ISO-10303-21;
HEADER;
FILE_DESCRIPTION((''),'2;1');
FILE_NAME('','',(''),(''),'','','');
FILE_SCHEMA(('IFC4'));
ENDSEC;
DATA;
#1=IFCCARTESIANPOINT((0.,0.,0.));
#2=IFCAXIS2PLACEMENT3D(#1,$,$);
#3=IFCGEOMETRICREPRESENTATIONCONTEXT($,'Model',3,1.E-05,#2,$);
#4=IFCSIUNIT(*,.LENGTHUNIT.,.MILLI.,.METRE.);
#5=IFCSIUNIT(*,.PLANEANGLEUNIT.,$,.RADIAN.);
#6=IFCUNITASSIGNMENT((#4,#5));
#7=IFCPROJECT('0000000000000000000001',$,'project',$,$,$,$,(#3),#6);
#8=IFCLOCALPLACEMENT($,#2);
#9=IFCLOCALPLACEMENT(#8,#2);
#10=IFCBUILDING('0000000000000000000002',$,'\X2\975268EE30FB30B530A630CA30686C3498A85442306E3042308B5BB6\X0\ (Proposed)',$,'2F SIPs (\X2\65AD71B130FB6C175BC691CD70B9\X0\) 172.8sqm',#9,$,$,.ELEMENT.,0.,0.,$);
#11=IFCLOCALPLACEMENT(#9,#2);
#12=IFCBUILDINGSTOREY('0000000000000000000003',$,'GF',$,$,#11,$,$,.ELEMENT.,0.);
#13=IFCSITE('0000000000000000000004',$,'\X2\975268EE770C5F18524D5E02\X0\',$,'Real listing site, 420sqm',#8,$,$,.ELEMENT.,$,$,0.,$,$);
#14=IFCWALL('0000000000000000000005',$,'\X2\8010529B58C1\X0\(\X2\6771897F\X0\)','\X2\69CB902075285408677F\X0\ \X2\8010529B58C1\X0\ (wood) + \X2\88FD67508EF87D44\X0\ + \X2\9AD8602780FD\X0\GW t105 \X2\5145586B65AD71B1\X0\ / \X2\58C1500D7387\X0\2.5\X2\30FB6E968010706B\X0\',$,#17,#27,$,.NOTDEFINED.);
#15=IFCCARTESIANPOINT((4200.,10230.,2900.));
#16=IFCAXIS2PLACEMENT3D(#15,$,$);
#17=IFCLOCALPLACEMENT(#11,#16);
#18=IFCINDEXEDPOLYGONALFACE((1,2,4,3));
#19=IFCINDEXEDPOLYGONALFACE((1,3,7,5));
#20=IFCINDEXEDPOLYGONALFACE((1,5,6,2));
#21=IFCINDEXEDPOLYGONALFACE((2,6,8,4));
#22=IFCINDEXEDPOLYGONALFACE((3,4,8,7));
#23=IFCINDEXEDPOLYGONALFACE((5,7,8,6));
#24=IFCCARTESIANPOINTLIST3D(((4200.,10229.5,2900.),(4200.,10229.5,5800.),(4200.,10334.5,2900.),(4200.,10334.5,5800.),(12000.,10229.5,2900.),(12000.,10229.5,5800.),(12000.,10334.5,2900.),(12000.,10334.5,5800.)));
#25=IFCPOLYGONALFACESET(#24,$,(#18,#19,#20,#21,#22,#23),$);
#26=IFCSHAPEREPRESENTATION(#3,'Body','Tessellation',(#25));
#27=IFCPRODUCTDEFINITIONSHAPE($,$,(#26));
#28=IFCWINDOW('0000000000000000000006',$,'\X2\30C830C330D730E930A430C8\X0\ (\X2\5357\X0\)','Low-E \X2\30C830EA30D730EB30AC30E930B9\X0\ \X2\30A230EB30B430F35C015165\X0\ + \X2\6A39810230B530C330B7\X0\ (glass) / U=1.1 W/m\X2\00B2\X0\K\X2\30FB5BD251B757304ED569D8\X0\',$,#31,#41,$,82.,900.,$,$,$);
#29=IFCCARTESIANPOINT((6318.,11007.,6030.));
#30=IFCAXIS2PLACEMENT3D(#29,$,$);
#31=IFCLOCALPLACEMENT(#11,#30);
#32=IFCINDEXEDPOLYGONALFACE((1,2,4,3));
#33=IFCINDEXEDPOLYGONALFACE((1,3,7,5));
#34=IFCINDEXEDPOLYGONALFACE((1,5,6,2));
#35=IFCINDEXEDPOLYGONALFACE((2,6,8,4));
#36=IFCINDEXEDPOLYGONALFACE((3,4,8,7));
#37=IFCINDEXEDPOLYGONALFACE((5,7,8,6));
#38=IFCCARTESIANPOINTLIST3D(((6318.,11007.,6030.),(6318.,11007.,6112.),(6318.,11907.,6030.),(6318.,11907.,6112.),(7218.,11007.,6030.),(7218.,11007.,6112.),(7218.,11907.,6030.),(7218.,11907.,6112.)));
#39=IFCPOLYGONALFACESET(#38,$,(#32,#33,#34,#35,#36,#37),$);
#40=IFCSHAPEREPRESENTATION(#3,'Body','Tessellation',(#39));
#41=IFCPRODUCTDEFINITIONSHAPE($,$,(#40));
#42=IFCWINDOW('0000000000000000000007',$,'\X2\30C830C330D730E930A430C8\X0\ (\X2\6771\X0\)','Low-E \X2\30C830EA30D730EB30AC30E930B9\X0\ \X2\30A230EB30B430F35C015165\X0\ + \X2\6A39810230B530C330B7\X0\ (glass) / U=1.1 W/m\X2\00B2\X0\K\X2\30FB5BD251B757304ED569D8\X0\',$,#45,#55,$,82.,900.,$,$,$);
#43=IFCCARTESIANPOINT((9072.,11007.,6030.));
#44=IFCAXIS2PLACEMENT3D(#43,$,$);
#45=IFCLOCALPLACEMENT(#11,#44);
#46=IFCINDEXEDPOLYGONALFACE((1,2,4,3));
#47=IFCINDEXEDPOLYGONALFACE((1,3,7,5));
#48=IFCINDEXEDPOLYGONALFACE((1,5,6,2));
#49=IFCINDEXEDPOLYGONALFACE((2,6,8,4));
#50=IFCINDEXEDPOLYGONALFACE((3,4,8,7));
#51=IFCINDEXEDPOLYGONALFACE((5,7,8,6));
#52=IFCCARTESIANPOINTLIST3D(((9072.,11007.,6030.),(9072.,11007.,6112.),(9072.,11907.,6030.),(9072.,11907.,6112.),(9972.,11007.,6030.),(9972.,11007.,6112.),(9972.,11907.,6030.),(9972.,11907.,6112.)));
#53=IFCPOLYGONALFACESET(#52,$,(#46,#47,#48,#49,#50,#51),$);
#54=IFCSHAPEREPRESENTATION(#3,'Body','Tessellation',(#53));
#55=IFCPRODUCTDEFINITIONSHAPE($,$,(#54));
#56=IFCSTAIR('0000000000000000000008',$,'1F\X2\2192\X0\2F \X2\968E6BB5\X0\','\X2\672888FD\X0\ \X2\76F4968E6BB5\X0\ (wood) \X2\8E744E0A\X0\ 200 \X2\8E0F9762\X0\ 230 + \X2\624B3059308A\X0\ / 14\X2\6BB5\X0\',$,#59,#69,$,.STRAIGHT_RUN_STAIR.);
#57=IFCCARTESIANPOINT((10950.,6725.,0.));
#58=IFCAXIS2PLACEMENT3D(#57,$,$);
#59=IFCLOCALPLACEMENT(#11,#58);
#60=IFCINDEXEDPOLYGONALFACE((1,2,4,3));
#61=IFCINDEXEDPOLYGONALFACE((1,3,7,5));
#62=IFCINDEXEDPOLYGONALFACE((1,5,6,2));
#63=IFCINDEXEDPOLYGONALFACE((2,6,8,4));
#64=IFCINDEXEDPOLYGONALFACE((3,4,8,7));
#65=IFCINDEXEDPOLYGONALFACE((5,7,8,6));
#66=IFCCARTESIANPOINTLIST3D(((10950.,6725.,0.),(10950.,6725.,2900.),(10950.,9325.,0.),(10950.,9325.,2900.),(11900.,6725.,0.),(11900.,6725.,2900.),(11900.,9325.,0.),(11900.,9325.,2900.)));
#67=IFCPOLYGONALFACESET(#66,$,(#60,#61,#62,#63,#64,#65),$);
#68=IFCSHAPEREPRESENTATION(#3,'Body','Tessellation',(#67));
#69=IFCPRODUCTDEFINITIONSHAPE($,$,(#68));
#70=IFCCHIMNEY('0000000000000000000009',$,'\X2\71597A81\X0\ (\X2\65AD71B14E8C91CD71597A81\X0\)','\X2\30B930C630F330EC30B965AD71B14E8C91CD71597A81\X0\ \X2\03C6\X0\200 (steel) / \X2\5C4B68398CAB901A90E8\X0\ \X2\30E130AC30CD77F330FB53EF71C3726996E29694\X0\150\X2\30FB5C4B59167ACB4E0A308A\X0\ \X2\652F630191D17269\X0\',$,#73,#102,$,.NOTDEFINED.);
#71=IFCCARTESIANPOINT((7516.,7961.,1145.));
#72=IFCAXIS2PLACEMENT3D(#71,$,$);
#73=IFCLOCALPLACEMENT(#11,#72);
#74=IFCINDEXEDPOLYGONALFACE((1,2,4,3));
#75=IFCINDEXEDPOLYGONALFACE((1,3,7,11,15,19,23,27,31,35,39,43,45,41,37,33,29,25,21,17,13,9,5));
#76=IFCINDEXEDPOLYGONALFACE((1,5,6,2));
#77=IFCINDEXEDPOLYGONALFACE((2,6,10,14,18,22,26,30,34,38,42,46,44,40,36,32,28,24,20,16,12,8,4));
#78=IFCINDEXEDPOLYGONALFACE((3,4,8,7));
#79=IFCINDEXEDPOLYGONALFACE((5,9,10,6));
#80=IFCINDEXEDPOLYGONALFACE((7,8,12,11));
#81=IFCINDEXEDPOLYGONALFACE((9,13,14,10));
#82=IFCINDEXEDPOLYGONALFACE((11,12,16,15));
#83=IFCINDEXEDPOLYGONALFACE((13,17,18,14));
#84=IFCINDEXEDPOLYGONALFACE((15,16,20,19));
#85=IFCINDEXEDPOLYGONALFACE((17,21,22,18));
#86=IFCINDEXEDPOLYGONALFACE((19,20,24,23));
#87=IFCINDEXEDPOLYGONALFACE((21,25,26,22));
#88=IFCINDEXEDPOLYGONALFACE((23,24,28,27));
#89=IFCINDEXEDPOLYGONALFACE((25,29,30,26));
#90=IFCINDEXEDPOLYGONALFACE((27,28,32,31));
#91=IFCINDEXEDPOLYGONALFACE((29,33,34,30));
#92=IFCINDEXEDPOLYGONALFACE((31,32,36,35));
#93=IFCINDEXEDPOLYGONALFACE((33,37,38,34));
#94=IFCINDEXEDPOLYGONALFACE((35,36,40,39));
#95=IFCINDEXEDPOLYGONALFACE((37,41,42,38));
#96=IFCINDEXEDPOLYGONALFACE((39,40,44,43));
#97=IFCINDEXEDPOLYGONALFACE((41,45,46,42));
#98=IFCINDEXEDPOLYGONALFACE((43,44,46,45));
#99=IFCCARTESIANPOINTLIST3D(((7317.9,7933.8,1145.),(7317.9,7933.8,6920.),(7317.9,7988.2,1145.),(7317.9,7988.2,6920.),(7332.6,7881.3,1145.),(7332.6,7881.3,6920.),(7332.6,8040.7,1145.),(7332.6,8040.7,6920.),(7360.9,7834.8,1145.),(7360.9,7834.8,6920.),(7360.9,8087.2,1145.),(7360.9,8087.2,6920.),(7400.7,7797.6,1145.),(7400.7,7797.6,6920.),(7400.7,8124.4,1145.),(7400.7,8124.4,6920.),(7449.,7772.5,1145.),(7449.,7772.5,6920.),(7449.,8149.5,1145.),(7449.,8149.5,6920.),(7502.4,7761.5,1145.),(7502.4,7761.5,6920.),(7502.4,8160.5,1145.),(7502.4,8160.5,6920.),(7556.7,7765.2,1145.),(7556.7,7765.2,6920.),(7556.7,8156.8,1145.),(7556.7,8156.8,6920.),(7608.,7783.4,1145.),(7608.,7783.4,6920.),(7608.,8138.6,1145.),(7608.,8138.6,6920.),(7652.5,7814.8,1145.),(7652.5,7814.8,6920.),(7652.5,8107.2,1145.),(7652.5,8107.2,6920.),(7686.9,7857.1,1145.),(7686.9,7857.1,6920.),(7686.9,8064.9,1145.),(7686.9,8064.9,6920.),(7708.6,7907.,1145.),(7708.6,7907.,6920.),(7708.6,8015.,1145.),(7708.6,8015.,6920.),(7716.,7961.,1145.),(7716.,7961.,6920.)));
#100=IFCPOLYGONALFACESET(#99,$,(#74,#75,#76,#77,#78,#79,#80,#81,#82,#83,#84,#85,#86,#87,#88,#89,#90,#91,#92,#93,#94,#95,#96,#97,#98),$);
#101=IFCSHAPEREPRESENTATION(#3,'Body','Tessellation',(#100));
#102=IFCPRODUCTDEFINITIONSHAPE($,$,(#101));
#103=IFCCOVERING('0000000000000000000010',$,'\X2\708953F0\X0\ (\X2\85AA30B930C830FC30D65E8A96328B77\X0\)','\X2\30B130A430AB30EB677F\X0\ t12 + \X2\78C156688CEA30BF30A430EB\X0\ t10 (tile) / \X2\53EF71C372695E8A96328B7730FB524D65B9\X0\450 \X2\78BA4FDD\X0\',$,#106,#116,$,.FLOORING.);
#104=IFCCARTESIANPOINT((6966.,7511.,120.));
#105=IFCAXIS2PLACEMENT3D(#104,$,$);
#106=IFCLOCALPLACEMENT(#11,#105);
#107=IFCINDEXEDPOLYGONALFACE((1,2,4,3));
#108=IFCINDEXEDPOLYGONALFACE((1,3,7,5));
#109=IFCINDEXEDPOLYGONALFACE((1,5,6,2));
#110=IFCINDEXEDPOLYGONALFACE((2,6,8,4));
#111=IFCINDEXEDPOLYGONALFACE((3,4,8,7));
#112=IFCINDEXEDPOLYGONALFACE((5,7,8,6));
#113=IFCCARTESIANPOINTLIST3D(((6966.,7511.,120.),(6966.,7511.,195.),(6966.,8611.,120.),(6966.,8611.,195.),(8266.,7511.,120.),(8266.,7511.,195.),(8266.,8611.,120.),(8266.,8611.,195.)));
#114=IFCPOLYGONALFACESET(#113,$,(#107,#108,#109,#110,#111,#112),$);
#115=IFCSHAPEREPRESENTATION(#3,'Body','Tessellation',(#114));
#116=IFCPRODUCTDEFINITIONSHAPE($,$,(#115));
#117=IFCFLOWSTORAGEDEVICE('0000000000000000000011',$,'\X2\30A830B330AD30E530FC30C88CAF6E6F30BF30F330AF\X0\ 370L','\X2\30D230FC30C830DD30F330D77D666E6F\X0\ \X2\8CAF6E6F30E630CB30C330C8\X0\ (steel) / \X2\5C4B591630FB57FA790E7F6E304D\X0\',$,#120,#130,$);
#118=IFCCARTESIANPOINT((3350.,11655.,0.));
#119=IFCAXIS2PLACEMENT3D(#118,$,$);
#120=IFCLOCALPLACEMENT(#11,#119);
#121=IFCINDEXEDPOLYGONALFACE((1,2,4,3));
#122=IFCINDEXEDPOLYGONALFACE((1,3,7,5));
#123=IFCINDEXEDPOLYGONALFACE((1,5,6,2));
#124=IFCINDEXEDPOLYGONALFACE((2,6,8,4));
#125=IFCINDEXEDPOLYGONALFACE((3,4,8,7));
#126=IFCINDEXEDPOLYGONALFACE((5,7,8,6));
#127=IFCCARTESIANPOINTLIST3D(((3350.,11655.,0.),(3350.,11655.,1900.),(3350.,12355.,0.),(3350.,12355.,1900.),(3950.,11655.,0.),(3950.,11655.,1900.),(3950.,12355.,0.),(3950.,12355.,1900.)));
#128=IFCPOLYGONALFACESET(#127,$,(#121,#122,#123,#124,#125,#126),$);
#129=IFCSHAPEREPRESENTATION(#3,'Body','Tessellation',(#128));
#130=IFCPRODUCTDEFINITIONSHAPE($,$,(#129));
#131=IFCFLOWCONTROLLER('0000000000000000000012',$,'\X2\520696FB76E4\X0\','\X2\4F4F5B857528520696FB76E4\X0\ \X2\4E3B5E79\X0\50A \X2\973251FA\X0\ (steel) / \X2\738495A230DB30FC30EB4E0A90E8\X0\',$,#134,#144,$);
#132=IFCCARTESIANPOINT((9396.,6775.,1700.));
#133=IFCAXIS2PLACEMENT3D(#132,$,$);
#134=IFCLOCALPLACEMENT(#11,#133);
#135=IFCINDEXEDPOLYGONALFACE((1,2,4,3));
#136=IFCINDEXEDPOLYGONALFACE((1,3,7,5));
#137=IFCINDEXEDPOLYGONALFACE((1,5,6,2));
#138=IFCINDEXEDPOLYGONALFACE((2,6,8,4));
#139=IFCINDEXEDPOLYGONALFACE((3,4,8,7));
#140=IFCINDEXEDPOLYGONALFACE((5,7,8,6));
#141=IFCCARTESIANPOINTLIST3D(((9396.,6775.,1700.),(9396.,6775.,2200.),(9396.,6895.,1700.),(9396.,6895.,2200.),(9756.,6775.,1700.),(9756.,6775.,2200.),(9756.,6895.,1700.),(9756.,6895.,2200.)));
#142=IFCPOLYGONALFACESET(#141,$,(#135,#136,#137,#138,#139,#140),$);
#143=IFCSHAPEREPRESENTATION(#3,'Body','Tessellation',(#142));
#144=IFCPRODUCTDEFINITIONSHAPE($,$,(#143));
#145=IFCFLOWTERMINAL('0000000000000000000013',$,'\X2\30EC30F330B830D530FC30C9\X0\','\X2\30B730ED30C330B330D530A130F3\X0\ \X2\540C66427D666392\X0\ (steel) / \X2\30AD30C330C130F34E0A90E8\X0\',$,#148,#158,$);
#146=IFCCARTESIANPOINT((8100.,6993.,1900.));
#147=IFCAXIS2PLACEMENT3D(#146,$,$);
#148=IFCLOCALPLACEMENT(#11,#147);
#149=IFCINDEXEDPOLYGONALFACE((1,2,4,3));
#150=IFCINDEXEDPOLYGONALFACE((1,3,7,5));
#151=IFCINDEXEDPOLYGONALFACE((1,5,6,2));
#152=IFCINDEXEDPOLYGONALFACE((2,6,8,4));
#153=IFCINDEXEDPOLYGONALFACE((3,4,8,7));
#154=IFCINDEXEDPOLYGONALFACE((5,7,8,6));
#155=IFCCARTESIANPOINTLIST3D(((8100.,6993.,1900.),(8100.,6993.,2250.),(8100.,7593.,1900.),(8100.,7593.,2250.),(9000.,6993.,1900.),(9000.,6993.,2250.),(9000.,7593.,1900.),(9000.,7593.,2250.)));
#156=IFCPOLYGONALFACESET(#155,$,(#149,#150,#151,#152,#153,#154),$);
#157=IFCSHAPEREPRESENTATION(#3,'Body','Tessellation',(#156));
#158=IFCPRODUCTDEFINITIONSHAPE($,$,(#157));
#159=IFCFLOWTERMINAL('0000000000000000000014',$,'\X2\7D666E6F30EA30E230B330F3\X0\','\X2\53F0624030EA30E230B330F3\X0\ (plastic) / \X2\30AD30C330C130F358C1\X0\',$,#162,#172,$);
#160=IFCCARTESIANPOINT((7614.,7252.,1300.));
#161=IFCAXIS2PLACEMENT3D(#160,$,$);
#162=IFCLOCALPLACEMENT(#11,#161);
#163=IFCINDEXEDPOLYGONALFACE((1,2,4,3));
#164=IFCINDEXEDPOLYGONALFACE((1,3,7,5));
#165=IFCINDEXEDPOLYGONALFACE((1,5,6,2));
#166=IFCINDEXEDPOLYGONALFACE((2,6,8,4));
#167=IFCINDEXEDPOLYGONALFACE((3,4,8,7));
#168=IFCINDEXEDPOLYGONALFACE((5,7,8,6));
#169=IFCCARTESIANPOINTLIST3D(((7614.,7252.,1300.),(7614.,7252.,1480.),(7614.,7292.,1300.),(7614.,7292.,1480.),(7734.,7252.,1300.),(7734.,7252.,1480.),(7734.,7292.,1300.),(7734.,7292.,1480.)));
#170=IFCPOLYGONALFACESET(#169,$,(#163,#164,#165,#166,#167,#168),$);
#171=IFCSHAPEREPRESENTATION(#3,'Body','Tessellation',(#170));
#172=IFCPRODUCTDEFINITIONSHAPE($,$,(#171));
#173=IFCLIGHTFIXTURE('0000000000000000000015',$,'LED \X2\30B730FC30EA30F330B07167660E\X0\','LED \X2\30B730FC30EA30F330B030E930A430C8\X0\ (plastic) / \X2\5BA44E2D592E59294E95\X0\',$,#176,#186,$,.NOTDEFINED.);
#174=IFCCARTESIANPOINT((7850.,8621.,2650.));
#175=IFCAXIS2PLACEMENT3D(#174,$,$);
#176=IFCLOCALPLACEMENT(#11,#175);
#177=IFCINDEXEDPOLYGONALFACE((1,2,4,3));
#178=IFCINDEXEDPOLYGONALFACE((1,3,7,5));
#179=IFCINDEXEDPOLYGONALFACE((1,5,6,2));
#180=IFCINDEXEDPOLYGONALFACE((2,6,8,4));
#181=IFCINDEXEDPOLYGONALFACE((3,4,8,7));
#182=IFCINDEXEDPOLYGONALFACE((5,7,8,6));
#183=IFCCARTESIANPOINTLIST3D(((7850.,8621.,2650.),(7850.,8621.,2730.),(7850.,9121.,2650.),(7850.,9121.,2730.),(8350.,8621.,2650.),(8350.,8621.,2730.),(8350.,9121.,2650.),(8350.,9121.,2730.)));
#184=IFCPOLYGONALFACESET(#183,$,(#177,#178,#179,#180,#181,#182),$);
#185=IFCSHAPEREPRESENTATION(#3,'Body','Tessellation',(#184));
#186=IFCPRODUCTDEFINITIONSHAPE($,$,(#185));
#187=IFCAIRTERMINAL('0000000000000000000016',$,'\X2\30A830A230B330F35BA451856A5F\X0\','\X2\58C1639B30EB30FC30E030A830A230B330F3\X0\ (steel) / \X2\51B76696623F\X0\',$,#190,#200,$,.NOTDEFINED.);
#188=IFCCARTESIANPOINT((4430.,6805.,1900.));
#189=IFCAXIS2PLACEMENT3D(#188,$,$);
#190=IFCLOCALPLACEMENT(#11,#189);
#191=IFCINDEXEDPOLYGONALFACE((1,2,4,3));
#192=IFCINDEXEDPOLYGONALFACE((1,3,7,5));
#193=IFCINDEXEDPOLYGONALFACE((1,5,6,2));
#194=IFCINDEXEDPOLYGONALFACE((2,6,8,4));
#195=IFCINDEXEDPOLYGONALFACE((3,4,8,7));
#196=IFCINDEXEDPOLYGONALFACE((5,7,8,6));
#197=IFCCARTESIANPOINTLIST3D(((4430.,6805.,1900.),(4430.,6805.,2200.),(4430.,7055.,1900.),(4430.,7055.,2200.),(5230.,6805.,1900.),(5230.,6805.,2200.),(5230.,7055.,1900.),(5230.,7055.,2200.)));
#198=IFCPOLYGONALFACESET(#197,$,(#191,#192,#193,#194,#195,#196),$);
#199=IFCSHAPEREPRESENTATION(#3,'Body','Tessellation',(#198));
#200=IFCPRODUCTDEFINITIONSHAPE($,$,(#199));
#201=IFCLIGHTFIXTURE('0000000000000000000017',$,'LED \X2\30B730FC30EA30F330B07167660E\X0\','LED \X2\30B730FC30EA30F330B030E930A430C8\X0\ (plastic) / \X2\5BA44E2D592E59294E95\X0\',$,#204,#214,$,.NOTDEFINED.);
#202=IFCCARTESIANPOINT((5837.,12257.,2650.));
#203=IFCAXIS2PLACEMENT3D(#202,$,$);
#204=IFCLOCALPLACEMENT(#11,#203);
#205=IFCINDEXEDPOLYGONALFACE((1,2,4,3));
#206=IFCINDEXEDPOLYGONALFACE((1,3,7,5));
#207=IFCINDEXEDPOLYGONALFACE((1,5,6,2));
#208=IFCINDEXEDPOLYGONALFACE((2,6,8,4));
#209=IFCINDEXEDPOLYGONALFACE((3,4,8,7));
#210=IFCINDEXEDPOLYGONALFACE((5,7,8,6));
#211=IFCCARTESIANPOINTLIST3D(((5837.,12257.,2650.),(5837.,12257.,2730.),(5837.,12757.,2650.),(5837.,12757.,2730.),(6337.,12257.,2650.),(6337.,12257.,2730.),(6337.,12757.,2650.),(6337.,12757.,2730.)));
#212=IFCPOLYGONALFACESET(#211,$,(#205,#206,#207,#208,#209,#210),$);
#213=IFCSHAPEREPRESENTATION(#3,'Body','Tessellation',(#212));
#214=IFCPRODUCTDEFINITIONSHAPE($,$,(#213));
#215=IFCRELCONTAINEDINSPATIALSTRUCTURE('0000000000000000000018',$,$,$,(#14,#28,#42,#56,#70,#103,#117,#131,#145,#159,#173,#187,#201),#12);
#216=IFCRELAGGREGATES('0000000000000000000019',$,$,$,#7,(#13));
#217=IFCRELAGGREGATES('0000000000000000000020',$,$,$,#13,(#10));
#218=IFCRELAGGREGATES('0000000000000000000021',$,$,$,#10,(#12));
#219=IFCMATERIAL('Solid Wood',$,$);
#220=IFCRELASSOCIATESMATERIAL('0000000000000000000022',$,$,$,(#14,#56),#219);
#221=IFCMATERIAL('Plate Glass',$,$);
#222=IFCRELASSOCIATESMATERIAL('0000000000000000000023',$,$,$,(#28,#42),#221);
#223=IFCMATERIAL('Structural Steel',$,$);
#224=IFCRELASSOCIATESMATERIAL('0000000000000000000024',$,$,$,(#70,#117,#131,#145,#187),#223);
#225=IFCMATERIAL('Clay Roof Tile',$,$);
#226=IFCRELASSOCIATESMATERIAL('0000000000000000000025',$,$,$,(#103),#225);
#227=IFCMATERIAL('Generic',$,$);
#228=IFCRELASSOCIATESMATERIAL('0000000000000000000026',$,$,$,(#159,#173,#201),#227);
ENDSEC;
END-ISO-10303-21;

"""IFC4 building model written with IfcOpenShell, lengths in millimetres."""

from ifc_helpers import new_model, si_unit, frame, frame_2d, origin, origin_2d, place, context, project, spatial, rectangle, circle, extrude, material, element, save


model = new_model("IFC4")

# Units and contexts
model_context = context("Model", 3, precision=1e-05, world=origin())
ifc_project = project(units=[si_unit("LENGTHUNIT", "METRE", prefix="MILLI"), si_unit("PLANEANGLEUNIT", "RADIAN")], contexts=[model_context])

# Site, building, storey
site_placement = place(None, origin())
site = spatial("IfcSite", under=ifc_project, at=site_placement, Name="青森県弘前市", ObjectType="Real listing site, 420sqm", CompositionType="ELEMENT", RefElevation=0.0)
building_placement = place(site_placement, origin())
building = spatial("IfcBuilding", under=site, at=building_placement, Name="青森・サウナと水風呂のある家 (Proposed)", ObjectType="2F SIPs (断熱・気密重点) 172.8sqm", CompositionType="ELEMENT", ElevationOfRefHeight=0.0, ElevationOfTerrain=0.0)
storey_placement = place(building_placement, origin())
storey = spatial("IfcBuildingStorey", under=building, at=storey_placement, Name="GF", CompositionType="ELEMENT", Elevation=0.0)

# Shared definitions
ifc_material_1 = material(Name="Solid Wood")

# Wall
wall_1_placement = place(storey_placement, frame((4200.0, 10230.0, 2900.0)))
element("IfcWall", 1, at=wall_1_placement, inside=storey, material=ifc_material_1, Name="耐力壁(東西)", Description="構造用合板 耐力壁 (wood) + 製材軸組 + 高性能GW t105 充填断熱 / 壁倍率2.5・準耐火", PredefinedType="NOTDEFINED", context=model_context, shape_type="SweptSolid", body=[
    extrude(rectangle(XDim=7800.0, YDim=105.0, at=frame_2d((3900.0, 52.0))), frame((4200.0, 10230.0, 2900.0)), (0.0, 0.0, 1.0), 2900.0),
])

# Windows
ifc_material_2 = material(Name="Plate Glass")
window_1_placement = place(storey_placement, frame((6318.0, 11007.0, 6030.0)))
element("IfcWindow", 2, at=window_1_placement, inside=storey, material=ifc_material_2, Name="トップライト (南)", Description="Low-E トリプルガラス アルゴン封入 + 樹脂サッシ (glass) / U=1.1 W/m²K・寒冷地仕様", OverallHeight=82.0, OverallWidth=900.0, context=model_context, shape_type="SweptSolid", body=[
    extrude(rectangle(XDim=900.0, YDim=900.0, at=frame_2d((450.0, 450.0))), frame((6318.0, 11007.0, 6030.0)), (0.0, 0.0, 1.0), 82.0),
])
window_2_placement = place(storey_placement, frame((9072.0, 11007.0, 6030.0)))
element("IfcWindow", 3, at=window_2_placement, inside=storey, material=ifc_material_2, Name="トップライト (東)", Description="Low-E トリプルガラス アルゴン封入 + 樹脂サッシ (glass) / U=1.1 W/m²K・寒冷地仕様", OverallHeight=82.0, OverallWidth=900.0, context=model_context, shape_type="SweptSolid", body=[
    extrude(rectangle(XDim=900.0, YDim=900.0, at=frame_2d((450.0, 450.0))), frame((9072.0, 11007.0, 6030.0)), (0.0, 0.0, 1.0), 82.0),
])

# Stair
stair_placement = place(storey_placement, frame((10950.0, 6725.0, 0.0)))
element("IfcStair", 4, at=stair_placement, inside=storey, material=ifc_material_1, Name="1F→2F 階段", Description="木製 直階段 (wood) 蹴上 200 踏面 230 + 手すり / 14段", PredefinedType="STRAIGHT_RUN_STAIR", context=model_context, shape_type="SweptSolid", body=[
    extrude(rectangle(XDim=950.0, YDim=2600.0, at=frame_2d((475.0, 1300.0))), frame((10950.0, 6725.0, 0.0)), (0.0, 0.0, 1.0), 2900.0),
])

# Chimney
ifc_material_3 = material(Name="Structural Steel")
chimney_placement = place(storey_placement, frame((7516.0, 7961.0, 1145.0)))
element("IfcChimney", 5, at=chimney_placement, inside=storey, material=ifc_material_3, Name="煙突 (断熱二重煙突)", Description="ステンレス断熱二重煙突 φ200 (steel) / 屋根貫通部 メガネ石・可燃物離隔150・屋外立上り 支持金物", PredefinedType="NOTDEFINED", context=model_context, shape_type="SweptSolid", body=[
    extrude(circle(Radius=200.0, at=origin_2d()), frame((7516.0, 7961.0, 1145.0)), (0.0, 0.0, 1.0), 5775.0),
])

# Covering
ifc_material_4 = material(Name="Clay Roof Tile")
covering_placement = place(storey_placement, frame((6966.0, 7511.0, 120.0)))
element("IfcCovering", 6, at=covering_placement, inside=storey, material=ifc_material_4, Name="炉台 (薪ストーブ床防護)", Description="ケイカル板 t12 + 磁器質タイル t10 (tile) / 可燃物床防護・前方450 確保", PredefinedType="FLOORING", context=model_context, shape_type="SweptSolid", body=[
    extrude(rectangle(XDim=1300.0, YDim=1100.0, at=frame_2d((650.0, 550.0))), frame((6966.0, 7511.0, 120.0)), (0.0, 0.0, 1.0), 75.0),
])

# Flow storage device
flow_storage_device_placement = place(storey_placement, frame((3350.0, 11655.0, 0.0)))
element("IfcFlowStorageDevice", 7, at=flow_storage_device_placement, inside=storey, material=ifc_material_3, Name="エコキュート貯湯タンク 370L", Description="ヒートポンプ給湯 貯湯ユニット (steel) / 屋外・基礎置き", context=model_context, shape_type="SweptSolid", body=[
    extrude(rectangle(XDim=600.0, YDim=700.0, at=frame_2d((300.0, 350.0))), frame((3350.0, 11655.0, 0.0)), (0.0, 0.0, 1.0), 1900.0),
])

# Flow controller
flow_controller_placement = place(storey_placement, frame((9396.0, 6775.0, 1700.0)))
element("IfcFlowController", 8, at=flow_controller_placement, inside=storey, material=ifc_material_3, Name="分電盤", Description="住宅用分電盤 主幹50A 露出 (steel) / 玄関ホール上部", context=model_context, shape_type="SweptSolid", body=[
    extrude(rectangle(XDim=360.0, YDim=120.0, at=frame_2d((180.0, 60.0))), frame((9396.0, 6775.0, 1700.0)), (0.0, 0.0, 1.0), 500.0),
])

# Flow terminals
flow_terminal_1_placement = place(storey_placement, frame((8100.0, 6993.0, 1900.0)))
element("IfcFlowTerminal", 9, at=flow_terminal_1_placement, inside=storey, material=ifc_material_3, Name="レンジフード", Description="シロッコファン 同時給排 (steel) / キッチン上部", context=model_context, shape_type="SweptSolid", body=[
    extrude(rectangle(XDim=900.0, YDim=600.0, at=frame_2d((450.0, 300.0))), frame((8100.0, 6993.0, 1900.0)), (0.0, 0.0, 1.0), 350.0),
])
ifc_material_5 = material(Name="Generic")
flow_terminal_2_placement = place(storey_placement, frame((7614.0, 7252.0, 1300.0)))
element("IfcFlowTerminal", 10, at=flow_terminal_2_placement, inside=storey, material=ifc_material_5, Name="給湯リモコン", Description="台所リモコン (plastic) / キッチン壁", context=model_context, shape_type="SweptSolid", body=[
    extrude(rectangle(XDim=120.0, YDim=40.0, at=frame_2d((60.0, 20.0))), frame((7614.0, 7252.0, 1300.0)), (0.0, 0.0, 1.0), 180.0),
])

# Light fixture
light_fixture_1_placement = place(storey_placement, frame((7850.0, 8621.0, 2650.0)))
element("IfcLightFixture", 11, at=light_fixture_1_placement, inside=storey, material=ifc_material_5, Name="LED シーリング照明", Description="LED シーリングライト (plastic) / 室中央天井", PredefinedType="NOTDEFINED", context=model_context, shape_type="SweptSolid", body=[
    extrude(rectangle(XDim=500.0, YDim=500.0, at=frame_2d((250.0, 250.0))), frame((7850.0, 8621.0, 2650.0)), (0.0, 0.0, 1.0), 80.0),
])

# Air terminal
air_terminal_1_placement = place(storey_placement, frame((4430.0, 6805.0, 1900.0)))
element("IfcAirTerminal", 12, at=air_terminal_1_placement, inside=storey, material=ifc_material_3, Name="エアコン室内機", Description="壁掛ルームエアコン (steel) / 冷暖房", PredefinedType="NOTDEFINED", context=model_context, shape_type="SweptSolid", body=[
    extrude(rectangle(XDim=800.0, YDim=250.0, at=frame_2d((400.0, 125.0))), frame((4430.0, 6805.0, 1900.0)), (0.0, 0.0, 1.0), 300.0),
])

# Light fixture
light_fixture_2_placement = place(storey_placement, frame((5837.0, 12257.0, 2650.0)))
element("IfcLightFixture", 13, at=light_fixture_2_placement, inside=storey, material=ifc_material_5, Name="LED シーリング照明", Description="LED シーリングライト (plastic) / 室中央天井", PredefinedType="NOTDEFINED", context=model_context, shape_type="SweptSolid", body=[
    extrude(rectangle(XDim=500.0, YDim=500.0, at=frame_2d((250.0, 250.0))), frame((5837.0, 12257.0, 2650.0)), (0.0, 0.0, 1.0), 80.0),
])

save(model, "model.ifc")
